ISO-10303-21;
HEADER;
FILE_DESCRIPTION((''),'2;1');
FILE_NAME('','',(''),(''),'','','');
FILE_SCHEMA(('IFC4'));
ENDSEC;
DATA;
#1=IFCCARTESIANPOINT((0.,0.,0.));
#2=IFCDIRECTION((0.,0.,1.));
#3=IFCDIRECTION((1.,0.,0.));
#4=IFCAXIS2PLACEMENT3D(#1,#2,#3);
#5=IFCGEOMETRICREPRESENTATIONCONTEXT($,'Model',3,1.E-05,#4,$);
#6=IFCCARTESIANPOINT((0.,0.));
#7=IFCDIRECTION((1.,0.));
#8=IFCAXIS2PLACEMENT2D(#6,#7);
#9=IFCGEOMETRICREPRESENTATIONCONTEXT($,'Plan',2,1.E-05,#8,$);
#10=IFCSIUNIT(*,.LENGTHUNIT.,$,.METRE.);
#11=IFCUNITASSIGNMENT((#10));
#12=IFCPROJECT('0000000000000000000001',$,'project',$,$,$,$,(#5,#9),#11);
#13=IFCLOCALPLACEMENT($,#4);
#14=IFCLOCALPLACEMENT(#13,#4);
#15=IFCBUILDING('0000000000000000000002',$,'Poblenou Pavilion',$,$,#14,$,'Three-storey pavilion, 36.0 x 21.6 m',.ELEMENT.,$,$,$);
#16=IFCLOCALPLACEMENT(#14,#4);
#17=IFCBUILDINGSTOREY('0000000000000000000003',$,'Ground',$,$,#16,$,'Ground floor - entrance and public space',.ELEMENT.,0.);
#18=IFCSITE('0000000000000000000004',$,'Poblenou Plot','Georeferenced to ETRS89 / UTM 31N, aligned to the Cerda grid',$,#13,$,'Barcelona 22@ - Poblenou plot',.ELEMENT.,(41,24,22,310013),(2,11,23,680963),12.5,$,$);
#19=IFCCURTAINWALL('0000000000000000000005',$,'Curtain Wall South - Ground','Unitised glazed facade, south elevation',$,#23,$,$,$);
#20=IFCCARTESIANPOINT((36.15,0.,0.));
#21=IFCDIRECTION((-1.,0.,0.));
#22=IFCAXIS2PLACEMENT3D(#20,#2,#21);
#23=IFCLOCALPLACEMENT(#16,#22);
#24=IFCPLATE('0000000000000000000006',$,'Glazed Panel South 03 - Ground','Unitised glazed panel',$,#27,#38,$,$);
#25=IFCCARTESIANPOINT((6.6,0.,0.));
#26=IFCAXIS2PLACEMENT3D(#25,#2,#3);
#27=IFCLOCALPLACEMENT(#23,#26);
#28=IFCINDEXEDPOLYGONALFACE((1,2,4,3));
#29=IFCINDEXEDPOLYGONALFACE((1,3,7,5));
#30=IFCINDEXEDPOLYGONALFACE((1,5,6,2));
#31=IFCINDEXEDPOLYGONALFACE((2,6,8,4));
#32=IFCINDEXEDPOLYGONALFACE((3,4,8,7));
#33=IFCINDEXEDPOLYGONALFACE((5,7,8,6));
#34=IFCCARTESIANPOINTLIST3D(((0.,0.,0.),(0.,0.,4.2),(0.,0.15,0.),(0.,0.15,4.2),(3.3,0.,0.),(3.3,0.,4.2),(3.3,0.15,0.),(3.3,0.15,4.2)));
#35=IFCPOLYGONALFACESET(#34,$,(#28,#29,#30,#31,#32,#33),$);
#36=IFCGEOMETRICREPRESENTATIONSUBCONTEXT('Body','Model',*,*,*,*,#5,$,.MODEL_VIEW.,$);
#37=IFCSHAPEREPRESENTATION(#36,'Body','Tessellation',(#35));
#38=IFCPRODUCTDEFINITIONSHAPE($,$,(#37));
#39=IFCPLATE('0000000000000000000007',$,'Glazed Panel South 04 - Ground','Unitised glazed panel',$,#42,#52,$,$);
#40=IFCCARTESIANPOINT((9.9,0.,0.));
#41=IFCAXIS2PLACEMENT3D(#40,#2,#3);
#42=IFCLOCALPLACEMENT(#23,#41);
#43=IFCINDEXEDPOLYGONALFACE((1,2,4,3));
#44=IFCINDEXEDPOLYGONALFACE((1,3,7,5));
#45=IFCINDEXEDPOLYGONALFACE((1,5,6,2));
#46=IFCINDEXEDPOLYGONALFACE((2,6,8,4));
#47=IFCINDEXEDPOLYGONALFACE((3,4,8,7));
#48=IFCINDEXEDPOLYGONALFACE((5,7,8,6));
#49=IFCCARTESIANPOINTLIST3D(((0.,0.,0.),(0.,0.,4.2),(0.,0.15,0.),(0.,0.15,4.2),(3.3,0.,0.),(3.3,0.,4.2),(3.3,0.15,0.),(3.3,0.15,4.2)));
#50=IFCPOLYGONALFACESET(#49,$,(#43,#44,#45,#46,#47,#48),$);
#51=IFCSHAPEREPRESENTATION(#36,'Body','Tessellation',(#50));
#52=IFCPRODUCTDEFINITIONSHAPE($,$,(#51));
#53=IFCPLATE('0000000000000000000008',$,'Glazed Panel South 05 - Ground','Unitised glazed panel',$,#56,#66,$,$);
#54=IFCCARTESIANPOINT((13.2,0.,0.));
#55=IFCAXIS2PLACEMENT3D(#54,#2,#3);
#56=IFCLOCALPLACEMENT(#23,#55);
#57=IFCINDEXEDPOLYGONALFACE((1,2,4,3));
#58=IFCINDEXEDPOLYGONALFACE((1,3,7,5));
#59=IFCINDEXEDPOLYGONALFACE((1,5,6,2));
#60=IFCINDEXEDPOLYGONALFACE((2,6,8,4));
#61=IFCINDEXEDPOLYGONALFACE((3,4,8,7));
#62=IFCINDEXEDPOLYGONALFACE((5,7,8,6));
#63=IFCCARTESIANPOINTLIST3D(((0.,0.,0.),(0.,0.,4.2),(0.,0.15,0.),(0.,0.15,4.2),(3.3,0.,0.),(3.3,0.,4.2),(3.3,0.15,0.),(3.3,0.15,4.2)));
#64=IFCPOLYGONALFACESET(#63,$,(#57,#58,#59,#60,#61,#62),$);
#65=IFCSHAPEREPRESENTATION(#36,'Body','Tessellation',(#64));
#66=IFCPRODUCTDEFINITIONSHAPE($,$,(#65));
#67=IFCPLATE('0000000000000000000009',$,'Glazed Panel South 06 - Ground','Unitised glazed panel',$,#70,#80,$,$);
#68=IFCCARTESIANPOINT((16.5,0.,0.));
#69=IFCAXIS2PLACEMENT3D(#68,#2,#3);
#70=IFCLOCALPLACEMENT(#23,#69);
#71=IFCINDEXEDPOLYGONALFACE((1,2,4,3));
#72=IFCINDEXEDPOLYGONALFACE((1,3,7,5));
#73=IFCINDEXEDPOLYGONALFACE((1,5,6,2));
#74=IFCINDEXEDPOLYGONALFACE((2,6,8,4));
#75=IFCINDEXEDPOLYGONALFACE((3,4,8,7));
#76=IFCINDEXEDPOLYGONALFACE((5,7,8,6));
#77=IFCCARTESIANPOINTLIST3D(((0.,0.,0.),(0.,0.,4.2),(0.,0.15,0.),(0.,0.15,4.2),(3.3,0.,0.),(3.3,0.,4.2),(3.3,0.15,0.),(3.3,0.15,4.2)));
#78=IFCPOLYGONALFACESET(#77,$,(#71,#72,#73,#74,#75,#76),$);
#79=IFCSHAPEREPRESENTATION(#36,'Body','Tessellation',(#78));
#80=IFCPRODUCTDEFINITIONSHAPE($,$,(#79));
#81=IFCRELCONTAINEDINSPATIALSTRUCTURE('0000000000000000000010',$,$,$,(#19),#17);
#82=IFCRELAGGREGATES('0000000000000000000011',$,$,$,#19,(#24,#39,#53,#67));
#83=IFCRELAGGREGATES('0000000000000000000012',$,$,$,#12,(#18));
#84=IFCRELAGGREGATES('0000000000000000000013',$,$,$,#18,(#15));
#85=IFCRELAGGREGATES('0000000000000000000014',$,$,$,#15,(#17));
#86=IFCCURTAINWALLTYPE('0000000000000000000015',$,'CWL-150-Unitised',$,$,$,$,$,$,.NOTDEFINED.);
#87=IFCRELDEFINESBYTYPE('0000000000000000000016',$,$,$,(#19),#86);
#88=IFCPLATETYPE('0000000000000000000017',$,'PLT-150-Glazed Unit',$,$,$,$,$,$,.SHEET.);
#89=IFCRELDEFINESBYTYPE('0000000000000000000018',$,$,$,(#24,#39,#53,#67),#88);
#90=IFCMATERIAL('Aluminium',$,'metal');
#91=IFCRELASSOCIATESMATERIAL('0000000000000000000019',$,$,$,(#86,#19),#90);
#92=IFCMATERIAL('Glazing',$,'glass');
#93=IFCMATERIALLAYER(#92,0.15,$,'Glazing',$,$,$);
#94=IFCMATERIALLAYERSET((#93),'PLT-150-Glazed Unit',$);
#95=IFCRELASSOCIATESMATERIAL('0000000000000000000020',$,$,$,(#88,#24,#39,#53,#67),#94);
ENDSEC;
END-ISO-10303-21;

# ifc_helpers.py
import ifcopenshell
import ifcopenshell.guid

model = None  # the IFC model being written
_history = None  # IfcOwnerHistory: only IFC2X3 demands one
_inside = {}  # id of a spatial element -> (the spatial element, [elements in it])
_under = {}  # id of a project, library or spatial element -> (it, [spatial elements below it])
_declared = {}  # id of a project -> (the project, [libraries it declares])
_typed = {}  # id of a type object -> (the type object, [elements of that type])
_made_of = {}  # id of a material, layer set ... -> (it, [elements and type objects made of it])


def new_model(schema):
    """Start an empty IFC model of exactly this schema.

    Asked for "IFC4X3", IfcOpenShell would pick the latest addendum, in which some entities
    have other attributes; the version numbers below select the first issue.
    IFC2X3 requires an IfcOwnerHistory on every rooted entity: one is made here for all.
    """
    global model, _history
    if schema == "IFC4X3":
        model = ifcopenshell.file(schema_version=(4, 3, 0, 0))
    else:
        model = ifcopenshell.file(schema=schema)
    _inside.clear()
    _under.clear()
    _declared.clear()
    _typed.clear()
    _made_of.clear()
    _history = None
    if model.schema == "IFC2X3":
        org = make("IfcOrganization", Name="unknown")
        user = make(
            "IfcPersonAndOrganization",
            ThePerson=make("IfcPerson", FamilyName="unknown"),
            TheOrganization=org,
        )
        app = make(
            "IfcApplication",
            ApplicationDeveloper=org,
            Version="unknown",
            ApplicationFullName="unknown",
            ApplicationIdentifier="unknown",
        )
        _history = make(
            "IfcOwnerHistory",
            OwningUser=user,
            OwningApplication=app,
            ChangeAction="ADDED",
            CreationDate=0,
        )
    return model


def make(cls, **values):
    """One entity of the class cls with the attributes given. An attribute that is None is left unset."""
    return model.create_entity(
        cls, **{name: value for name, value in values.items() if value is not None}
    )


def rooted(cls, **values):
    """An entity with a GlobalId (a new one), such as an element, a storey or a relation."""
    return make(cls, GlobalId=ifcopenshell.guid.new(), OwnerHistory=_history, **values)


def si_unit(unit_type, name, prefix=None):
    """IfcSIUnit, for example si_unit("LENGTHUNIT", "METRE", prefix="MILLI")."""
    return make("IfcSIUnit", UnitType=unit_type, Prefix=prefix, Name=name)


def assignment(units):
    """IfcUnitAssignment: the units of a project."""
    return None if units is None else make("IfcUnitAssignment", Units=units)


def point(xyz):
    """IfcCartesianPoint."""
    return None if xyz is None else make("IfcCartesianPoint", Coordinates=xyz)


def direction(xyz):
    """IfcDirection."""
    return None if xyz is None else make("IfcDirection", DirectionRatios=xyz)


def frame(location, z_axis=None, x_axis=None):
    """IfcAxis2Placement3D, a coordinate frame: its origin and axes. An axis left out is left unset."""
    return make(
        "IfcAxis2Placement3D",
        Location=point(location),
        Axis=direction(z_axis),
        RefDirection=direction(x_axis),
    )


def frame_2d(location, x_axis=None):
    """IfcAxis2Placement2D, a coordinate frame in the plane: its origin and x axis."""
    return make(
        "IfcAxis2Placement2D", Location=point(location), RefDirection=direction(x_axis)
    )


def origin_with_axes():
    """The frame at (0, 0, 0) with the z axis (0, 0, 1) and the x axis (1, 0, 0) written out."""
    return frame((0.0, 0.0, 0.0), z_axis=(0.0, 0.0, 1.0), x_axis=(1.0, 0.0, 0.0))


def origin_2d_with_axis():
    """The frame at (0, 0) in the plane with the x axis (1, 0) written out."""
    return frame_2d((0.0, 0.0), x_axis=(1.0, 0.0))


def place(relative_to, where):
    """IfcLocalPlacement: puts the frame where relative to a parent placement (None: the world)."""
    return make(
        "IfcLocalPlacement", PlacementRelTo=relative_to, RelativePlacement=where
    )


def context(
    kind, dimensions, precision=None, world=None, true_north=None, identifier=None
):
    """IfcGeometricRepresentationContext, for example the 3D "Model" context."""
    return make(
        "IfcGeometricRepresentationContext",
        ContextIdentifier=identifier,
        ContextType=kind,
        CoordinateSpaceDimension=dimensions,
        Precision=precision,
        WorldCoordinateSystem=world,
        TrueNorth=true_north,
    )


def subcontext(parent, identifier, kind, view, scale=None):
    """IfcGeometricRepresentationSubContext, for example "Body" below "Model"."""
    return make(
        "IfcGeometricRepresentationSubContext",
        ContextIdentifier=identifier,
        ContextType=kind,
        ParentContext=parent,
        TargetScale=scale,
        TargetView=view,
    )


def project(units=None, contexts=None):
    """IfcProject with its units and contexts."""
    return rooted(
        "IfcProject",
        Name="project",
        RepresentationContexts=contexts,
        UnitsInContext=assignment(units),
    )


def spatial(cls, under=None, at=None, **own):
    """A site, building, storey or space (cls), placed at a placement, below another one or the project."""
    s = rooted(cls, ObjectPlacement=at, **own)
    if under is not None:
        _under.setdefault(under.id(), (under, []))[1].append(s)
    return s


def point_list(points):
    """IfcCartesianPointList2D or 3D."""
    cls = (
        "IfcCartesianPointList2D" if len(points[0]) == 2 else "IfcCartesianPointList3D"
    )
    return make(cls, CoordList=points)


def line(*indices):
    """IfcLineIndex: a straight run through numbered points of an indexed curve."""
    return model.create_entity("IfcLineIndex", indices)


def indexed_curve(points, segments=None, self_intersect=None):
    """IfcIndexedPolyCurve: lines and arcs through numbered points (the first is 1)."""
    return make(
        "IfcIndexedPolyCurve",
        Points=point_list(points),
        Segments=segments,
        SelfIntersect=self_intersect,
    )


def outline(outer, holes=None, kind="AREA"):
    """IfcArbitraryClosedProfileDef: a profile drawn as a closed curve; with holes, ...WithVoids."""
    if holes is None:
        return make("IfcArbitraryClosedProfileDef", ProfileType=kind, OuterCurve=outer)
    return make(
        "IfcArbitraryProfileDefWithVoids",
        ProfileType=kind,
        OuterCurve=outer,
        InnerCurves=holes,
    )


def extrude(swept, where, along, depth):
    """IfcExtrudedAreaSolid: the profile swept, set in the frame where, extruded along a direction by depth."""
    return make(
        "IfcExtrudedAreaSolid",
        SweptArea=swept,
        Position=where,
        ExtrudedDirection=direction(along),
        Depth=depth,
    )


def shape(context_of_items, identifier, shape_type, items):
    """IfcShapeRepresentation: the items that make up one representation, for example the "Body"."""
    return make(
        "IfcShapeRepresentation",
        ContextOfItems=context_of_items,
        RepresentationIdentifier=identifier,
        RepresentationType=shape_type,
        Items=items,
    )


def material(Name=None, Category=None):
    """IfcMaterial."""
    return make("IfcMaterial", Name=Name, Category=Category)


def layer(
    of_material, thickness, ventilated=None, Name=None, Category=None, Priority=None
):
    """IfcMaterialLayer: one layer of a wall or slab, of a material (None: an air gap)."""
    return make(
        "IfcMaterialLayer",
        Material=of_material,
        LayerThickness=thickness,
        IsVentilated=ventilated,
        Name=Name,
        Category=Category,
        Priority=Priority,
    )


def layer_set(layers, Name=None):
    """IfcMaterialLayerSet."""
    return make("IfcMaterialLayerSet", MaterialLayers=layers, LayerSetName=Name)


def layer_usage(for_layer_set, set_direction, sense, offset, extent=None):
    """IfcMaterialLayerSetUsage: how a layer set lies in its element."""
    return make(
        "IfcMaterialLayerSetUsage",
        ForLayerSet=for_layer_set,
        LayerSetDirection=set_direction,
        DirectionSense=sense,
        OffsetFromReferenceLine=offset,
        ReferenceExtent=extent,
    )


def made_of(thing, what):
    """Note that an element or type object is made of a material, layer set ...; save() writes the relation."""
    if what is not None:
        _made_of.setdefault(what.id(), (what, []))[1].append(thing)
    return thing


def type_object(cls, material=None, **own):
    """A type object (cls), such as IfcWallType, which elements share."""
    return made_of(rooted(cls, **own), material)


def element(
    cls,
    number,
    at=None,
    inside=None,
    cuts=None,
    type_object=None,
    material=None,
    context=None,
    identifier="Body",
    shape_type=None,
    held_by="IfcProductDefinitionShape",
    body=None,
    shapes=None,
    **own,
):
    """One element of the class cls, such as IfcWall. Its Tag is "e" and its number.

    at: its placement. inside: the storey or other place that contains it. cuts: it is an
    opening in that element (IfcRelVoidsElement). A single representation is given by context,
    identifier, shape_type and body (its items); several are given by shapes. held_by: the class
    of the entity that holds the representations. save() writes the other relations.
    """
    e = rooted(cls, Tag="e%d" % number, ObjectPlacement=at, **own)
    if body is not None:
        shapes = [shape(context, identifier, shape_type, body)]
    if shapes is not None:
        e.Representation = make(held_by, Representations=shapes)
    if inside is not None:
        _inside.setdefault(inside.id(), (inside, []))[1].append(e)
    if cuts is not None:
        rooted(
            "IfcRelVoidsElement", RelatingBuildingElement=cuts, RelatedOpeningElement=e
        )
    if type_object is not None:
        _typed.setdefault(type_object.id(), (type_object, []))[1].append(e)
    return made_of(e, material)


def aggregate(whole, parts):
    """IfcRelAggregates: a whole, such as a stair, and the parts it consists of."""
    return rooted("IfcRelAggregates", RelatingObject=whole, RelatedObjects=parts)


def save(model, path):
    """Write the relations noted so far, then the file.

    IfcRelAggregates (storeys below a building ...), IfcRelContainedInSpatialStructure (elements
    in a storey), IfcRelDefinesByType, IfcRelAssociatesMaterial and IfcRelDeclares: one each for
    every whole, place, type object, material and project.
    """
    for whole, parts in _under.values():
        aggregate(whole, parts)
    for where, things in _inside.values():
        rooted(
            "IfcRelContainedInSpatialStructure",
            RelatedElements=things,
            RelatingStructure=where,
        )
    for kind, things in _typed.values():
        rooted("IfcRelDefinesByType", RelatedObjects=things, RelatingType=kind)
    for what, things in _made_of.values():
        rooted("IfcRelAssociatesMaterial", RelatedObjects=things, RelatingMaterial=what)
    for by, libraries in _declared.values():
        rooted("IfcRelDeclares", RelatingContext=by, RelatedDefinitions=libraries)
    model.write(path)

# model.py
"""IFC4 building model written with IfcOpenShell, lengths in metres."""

from ifc_helpers import new_model, si_unit, frame, origin_with_axes, origin_2d_with_axis, place, context, subcontext, project, spatial, line, indexed_curve, outline, extrude, material, layer, layer_set, layer_usage, type_object, element, aggregate, save


model = new_model("IFC4")

# Units and contexts
model_context = context("Model", 3, precision=1e-05, world=origin_with_axes())
plan_context = context("Plan", 2, precision=1e-05, world=origin_2d_with_axis())
body_context = subcontext(model_context, "Body", "Model", "MODEL_VIEW")
ifc_project = project(units=[si_unit("LENGTHUNIT", "METRE")], contexts=[model_context, plan_context])

# Site, building, storey
site_placement = place(None, origin_with_axes())
site = spatial("IfcSite", under=ifc_project, at=site_placement, Name="Poblenou Plot", Description="Georeferenced to ETRS89 / UTM 31N, aligned to the Cerda grid", LongName="Barcelona 22@ - Poblenou plot", CompositionType="ELEMENT", RefLatitude=(41, 24, 22, 310013), RefLongitude=(2, 11, 23, 680963), RefElevation=12.5)
building_placement = place(site_placement, origin_with_axes())
building = spatial("IfcBuilding", under=site, at=building_placement, Name="Poblenou Pavilion", LongName="Three-storey pavilion, 36.0 x 21.6 m", CompositionType="ELEMENT")
storey_placement = place(building_placement, origin_with_axes())
storey = spatial("IfcBuildingStorey", under=building, at=storey_placement, Name="Ground", LongName="Ground floor - entrance and public space", CompositionType="ELEMENT", Elevation=0.0)

# Curtain wall, plates
ifc_material_1 = material(Name="Aluminium", Category="metal")
curtain_wall_type = type_object("IfcCurtainWallType", Name="CWL-150-Unitised", PredefinedType="NOTDEFINED", material=ifc_material_1)
curtain_wall_1_placement = place(storey_placement, frame((36.15, 0.0, 0.0), z_axis=(0.0, 0.0, 1.0), x_axis=(-1.0, 0.0, 0.0)))
curtain_wall_1 = element("IfcCurtainWall", 1, at=curtain_wall_1_placement, inside=storey, type_object=curtain_wall_type, material=ifc_material_1, Name="Curtain Wall South - Ground", Description="Unitised glazed facade, south elevation")
ifc_material_2 = material(Name="Glazing", Category="glass")
ifc_layer_1 = layer(ifc_material_2, 0.15, Name="Glazing")
ifc_layer_set_1 = layer_set([ifc_layer_1], Name="PLT-150-Glazed Unit")
plate_type = type_object("IfcPlateType", Name="PLT-150-Glazed Unit", PredefinedType="SHEET", material=ifc_layer_set_1)
ifc_layer_usage_1 = layer_usage(ifc_layer_set_1, "AXIS2", "POSITIVE", 0.0)
plate_1_placement = place(curtain_wall_1_placement, frame((6.6, 0.0, 0.0), z_axis=(0.0, 0.0, 1.0), x_axis=(1.0, 0.0, 0.0)))
plate_1 = element("IfcPlate", 2, at=plate_1_placement, type_object=plate_type, material=ifc_layer_usage_1, Name="Glazed Panel South 03 - Ground", Description="Unitised glazed panel", context=body_context, shape_type="SweptSolid", body=[
    extrude(outline(indexed_curve([(0.0, 0.0), (3.3, 0.0), (3.3, 0.15), (0.0, 0.15)], segments=[line(1, 2, 3, 4, 1)])), origin_with_axes(), (0.0, 0.0, 1.0), 4.2),
])
ifc_layer_usage_2 = layer_usage(ifc_layer_set_1, "AXIS2", "POSITIVE", 0.0)
plate_2_placement = place(curtain_wall_1_placement, frame((9.9, 0.0, 0.0), z_axis=(0.0, 0.0, 1.0), x_axis=(1.0, 0.0, 0.0)))
plate_2 = element("IfcPlate", 3, at=plate_2_placement, type_object=plate_type, material=ifc_layer_usage_2, Name="Glazed Panel South 04 - Ground", Description="Unitised glazed panel", context=body_context, shape_type="SweptSolid", body=[
    extrude(outline(indexed_curve([(0.0, 0.0), (3.3, 0.0), (3.3, 0.15), (0.0, 0.15)], segments=[line(1, 2, 3, 4, 1)])), origin_with_axes(), (0.0, 0.0, 1.0), 4.2),
])
ifc_layer_usage_3 = layer_usage(ifc_layer_set_1, "AXIS2", "POSITIVE", 0.0)
plate_3_placement = place(curtain_wall_1_placement, frame((13.2, 0.0, 0.0), z_axis=(0.0, 0.0, 1.0), x_axis=(1.0, 0.0, 0.0)))
plate_3 = element("IfcPlate", 4, at=plate_3_placement, type_object=plate_type, material=ifc_layer_usage_3, Name="Glazed Panel South 05 - Ground", Description="Unitised glazed panel", context=body_context, shape_type="SweptSolid", body=[
    extrude(outline(indexed_curve([(0.0, 0.0), (3.3, 0.0), (3.3, 0.15), (0.0, 0.15)], segments=[line(1, 2, 3, 4, 1)])), origin_with_axes(), (0.0, 0.0, 1.0), 4.2),
])
ifc_layer_usage_4 = layer_usage(ifc_layer_set_1, "AXIS2", "POSITIVE", 0.0)
plate_4_placement = place(curtain_wall_1_placement, frame((16.5, 0.0, 0.0), z_axis=(0.0, 0.0, 1.0), x_axis=(1.0, 0.0, 0.0)))
plate_4 = element("IfcPlate", 5, at=plate_4_placement, type_object=plate_type, material=ifc_layer_usage_4, Name="Glazed Panel South 06 - Ground", Description="Unitised glazed panel", context=body_context, shape_type="SweptSolid", body=[
    extrude(outline(indexed_curve([(0.0, 0.0), (3.3, 0.0), (3.3, 0.15), (0.0, 0.15)], segments=[line(1, 2, 3, 4, 1)])), origin_with_axes(), (0.0, 0.0, 1.0), 4.2),
])
aggregate(curtain_wall_1, [plate_1, plate_2, plate_3, plate_4])

save(model, "model.ifc")
